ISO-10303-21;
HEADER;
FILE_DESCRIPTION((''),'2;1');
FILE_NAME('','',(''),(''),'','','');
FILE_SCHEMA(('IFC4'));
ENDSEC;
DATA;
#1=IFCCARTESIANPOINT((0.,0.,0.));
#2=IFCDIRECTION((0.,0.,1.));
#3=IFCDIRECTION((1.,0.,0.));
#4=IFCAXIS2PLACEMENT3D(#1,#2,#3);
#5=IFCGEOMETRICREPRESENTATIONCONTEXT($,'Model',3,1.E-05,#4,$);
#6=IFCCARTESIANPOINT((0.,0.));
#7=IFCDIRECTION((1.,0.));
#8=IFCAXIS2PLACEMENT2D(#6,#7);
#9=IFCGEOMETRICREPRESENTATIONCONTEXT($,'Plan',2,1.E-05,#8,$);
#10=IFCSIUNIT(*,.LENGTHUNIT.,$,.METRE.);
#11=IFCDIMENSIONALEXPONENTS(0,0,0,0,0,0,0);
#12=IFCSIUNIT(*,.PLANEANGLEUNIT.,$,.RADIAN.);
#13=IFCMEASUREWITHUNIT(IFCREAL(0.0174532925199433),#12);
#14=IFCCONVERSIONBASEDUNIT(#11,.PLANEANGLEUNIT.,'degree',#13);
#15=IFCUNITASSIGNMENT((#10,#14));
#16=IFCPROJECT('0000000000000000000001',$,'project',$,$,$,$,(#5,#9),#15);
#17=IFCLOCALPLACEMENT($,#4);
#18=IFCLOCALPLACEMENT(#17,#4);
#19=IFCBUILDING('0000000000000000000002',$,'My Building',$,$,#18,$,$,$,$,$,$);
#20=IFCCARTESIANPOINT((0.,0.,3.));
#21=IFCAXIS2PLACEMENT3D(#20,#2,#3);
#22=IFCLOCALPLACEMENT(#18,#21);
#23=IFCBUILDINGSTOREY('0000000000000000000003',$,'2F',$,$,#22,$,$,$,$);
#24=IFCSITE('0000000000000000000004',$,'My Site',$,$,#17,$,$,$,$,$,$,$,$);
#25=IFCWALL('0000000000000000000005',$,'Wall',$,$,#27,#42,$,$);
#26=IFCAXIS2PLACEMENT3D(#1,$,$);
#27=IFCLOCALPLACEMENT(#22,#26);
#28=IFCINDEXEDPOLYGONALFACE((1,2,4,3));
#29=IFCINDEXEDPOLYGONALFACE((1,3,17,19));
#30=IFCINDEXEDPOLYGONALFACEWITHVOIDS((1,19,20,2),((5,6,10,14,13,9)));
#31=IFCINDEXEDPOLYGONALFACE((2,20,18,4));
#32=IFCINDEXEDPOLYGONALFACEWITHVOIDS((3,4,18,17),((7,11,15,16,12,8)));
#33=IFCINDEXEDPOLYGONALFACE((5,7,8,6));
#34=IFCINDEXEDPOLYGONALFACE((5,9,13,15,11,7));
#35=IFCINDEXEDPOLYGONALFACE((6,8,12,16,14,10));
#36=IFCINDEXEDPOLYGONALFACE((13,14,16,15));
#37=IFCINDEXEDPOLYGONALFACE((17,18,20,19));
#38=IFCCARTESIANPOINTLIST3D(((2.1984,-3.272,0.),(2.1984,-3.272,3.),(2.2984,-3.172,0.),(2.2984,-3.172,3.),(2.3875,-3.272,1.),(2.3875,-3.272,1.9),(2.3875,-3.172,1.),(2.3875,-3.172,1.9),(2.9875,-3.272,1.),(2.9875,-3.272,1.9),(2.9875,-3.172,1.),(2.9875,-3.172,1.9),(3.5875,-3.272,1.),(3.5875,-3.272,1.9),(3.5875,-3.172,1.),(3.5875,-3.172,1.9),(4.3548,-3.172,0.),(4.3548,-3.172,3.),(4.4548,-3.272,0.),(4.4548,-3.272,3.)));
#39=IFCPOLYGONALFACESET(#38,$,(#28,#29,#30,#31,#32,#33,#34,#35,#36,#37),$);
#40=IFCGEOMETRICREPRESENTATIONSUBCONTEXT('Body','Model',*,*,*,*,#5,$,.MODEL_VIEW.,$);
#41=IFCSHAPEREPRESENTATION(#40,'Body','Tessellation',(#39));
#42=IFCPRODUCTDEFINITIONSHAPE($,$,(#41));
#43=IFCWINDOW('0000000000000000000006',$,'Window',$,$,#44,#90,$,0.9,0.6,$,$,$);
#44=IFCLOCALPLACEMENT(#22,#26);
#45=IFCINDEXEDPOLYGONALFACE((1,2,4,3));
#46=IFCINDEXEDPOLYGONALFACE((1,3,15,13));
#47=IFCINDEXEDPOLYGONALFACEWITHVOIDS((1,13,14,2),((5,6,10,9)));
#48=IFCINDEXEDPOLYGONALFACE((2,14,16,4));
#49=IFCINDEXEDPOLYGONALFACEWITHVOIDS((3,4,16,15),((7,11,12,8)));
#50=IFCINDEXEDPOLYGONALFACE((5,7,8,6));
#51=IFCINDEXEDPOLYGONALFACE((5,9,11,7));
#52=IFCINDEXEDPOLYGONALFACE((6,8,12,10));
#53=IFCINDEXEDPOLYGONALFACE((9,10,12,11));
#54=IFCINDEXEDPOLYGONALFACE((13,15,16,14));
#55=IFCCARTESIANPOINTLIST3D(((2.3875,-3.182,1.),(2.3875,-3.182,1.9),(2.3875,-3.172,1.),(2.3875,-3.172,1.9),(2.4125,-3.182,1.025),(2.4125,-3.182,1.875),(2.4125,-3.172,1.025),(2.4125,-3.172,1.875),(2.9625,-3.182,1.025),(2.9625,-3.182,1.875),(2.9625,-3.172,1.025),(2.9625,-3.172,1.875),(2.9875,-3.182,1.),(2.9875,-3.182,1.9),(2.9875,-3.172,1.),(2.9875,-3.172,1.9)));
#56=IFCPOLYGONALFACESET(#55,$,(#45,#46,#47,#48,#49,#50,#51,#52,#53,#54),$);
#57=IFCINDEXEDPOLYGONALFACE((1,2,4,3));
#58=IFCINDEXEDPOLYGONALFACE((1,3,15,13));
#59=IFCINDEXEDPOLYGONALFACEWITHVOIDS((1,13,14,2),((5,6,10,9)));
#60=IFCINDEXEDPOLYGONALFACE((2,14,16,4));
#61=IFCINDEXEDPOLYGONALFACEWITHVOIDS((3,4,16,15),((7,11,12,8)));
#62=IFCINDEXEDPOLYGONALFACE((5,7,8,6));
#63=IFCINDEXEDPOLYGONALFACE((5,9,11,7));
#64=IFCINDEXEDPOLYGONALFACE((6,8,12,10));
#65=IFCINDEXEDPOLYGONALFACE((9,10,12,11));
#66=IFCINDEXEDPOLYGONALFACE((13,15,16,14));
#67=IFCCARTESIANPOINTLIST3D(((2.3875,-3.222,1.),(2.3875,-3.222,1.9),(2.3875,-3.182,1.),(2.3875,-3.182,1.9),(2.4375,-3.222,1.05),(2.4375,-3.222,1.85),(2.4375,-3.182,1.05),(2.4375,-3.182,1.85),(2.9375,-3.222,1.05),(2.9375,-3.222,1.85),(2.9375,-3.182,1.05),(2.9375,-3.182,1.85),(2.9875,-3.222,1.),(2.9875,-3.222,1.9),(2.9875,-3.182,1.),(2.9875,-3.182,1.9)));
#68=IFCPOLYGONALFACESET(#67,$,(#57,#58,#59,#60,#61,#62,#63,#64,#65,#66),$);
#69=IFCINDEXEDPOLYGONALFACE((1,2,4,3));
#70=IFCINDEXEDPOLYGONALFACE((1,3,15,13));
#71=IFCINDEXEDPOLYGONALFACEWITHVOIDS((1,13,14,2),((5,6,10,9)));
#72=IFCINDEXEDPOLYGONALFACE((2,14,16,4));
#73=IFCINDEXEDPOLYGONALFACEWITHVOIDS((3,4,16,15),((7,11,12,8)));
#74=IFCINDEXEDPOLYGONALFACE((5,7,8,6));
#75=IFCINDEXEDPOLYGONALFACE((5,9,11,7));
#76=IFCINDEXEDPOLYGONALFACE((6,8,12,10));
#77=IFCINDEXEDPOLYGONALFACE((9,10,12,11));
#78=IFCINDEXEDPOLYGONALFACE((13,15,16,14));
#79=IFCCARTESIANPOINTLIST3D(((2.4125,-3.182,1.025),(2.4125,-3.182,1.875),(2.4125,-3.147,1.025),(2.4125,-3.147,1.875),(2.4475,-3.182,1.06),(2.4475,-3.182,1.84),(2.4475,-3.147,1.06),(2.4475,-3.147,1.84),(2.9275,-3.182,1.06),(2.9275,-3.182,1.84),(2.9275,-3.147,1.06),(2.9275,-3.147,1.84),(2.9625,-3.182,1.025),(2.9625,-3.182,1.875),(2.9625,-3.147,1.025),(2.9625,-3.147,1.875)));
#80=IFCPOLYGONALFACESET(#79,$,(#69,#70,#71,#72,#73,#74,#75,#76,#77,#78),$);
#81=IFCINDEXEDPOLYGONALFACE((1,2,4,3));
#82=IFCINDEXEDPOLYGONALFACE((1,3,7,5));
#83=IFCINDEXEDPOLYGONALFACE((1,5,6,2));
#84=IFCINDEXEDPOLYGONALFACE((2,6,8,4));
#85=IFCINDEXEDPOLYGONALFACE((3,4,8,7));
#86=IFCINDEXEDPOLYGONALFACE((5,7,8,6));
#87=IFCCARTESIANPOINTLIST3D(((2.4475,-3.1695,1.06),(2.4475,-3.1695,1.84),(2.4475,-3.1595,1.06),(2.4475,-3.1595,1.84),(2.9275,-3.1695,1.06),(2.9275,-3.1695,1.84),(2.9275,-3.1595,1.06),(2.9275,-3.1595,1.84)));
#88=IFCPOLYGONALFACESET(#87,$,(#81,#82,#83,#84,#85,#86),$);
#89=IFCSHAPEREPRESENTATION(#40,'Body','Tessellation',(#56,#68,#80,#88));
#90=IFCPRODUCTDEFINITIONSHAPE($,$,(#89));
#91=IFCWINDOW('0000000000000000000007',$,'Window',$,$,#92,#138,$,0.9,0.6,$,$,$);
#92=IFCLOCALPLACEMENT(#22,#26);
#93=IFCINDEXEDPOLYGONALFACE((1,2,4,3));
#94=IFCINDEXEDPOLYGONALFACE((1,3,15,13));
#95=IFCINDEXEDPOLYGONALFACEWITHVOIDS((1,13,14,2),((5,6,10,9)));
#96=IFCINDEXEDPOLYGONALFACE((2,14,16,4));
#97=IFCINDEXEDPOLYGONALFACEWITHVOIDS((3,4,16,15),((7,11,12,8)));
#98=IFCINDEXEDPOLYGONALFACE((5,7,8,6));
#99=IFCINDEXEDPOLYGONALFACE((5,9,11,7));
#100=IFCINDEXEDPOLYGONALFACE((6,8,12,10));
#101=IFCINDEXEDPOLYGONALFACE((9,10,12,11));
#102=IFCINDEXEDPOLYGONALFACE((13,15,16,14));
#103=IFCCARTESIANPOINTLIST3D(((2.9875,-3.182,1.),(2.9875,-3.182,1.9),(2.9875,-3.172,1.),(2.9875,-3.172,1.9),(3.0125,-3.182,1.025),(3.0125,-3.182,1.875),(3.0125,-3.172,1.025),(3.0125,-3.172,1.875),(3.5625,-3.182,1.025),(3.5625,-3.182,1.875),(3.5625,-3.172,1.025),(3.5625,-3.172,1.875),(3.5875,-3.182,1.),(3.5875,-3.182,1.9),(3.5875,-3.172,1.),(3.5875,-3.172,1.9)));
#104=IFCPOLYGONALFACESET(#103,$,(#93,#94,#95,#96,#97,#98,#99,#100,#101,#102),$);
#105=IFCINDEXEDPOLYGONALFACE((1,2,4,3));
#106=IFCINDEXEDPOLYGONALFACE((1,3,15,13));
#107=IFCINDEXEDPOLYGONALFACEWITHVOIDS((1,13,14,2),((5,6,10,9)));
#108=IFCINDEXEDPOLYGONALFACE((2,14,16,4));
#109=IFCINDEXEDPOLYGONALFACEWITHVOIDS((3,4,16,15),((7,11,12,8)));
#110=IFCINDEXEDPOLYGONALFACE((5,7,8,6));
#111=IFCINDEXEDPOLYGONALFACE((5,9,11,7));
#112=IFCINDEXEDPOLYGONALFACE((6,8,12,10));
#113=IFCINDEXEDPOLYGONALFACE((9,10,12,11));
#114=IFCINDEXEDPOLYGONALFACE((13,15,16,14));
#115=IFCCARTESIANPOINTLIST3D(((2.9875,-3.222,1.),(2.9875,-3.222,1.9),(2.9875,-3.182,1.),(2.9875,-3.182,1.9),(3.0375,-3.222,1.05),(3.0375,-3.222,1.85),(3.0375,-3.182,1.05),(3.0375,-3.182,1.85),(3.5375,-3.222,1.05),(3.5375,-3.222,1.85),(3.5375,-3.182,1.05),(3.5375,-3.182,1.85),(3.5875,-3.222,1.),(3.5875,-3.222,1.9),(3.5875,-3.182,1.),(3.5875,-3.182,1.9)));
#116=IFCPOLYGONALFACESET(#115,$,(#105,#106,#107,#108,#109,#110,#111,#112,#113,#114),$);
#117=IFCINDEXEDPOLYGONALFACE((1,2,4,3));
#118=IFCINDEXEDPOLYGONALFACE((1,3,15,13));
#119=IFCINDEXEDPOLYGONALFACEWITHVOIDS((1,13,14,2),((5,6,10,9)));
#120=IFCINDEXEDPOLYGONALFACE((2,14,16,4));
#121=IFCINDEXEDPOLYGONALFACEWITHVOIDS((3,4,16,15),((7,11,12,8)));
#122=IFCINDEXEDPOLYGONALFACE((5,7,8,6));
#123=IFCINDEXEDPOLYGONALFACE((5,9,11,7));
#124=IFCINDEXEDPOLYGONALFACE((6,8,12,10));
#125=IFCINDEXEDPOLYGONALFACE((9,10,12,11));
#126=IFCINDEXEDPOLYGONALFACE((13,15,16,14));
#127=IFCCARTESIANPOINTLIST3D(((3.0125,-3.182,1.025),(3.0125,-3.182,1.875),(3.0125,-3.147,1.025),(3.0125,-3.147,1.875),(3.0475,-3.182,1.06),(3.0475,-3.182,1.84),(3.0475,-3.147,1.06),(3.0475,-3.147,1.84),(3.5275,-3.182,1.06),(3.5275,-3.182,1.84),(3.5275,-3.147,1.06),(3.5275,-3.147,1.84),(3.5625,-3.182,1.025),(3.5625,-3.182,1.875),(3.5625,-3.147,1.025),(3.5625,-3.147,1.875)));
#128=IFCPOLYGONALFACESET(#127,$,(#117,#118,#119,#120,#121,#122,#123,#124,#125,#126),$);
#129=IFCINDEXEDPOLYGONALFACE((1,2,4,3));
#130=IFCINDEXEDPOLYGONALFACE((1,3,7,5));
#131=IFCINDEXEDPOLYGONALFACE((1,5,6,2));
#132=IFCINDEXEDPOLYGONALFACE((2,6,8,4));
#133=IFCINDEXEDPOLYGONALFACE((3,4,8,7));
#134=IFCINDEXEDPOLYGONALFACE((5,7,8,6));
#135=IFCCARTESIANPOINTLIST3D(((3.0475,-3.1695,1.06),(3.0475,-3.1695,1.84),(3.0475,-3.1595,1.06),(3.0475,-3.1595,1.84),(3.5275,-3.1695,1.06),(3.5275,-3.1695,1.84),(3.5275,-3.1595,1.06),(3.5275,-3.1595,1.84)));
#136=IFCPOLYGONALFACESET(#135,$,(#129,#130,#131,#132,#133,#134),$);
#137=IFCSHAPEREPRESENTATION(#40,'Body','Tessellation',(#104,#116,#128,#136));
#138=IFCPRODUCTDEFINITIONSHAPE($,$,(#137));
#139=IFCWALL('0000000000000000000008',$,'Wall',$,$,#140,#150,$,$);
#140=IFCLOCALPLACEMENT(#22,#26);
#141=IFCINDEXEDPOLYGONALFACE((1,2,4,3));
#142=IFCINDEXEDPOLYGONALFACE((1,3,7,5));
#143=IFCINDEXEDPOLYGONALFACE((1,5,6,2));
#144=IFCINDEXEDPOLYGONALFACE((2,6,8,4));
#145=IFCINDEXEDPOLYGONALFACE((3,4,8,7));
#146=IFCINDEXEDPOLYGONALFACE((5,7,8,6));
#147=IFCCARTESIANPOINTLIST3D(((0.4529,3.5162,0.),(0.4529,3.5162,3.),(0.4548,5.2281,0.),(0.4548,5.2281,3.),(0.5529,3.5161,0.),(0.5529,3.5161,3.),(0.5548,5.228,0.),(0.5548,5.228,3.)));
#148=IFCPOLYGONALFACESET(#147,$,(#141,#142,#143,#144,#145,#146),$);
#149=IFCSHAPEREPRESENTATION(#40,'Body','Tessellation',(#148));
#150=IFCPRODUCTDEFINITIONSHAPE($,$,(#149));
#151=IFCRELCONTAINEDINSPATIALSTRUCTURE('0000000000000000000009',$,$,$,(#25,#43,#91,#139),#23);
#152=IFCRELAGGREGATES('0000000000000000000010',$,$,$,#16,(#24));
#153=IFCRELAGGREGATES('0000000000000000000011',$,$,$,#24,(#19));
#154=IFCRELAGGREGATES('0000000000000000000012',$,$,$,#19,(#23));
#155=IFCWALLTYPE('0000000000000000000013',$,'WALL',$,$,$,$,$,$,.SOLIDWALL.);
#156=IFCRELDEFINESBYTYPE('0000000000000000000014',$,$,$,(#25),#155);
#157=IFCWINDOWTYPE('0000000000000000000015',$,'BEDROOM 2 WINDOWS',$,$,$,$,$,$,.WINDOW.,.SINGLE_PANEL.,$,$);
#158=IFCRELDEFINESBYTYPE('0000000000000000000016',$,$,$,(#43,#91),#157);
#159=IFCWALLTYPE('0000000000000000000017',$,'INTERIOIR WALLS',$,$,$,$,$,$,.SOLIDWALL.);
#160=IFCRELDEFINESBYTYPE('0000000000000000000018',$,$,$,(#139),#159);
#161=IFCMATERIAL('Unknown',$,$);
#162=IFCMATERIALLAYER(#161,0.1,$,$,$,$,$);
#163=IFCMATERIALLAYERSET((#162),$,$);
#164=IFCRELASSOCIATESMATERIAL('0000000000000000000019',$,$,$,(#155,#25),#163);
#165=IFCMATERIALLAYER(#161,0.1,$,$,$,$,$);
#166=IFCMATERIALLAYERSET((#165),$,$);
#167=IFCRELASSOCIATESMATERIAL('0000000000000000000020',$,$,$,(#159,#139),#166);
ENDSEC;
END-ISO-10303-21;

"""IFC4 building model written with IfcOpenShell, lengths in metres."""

from ifc_helpers import new_model, entity, si_unit, converted_unit, frame, origin_with_axes, origin_2d_with_axis, place, context, subcontext, project, spatial, line, indexed_curve, outline, extrude, shape, source, transform, mapped, material, layer, layer_set, layer_usage, type_object, type_shapes, element, fill, save


model = new_model("IFC4")

# Units and contexts
model_context = context("Model", 3, precision=1e-05, world=origin_with_axes())
plan_context = context("Plan", 2, precision=1e-05, world=origin_2d_with_axis())
body_context_1 = subcontext(model_context, "Body", "Model", "MODEL_VIEW")
body_context_2 = subcontext(plan_context, "Body", "Plan", "PLAN_VIEW")
ifc_project = project(units=[si_unit("LENGTHUNIT", "METRE"), converted_unit("PLANEANGLEUNIT", "degree", entity("IfcReal", 0.0174532925199433), si_unit("PLANEANGLEUNIT", "RADIAN"), dimensions=[0, 0, 0, 0, 0, 0, 0])], contexts=[model_context, plan_context])

# Site, building, storey
site_placement = place(None, origin_with_axes())
site = spatial("IfcSite", under=ifc_project, at=site_placement, Name="My Site")
building_placement = place(site_placement, origin_with_axes())
building = spatial("IfcBuilding", under=site, at=building_placement, Name="My Building")
storey_placement = place(building_placement, frame((0.0, 0.0, 3.0), z_axis=(0.0, 0.0, 1.0), x_axis=(1.0, 0.0, 0.0)))
storey = spatial("IfcBuildingStorey", under=building, at=storey_placement, Name="2F")

# Shared definitions
ifc_material = material(Name="Unknown")

# Shared definitions
ifc_layer_1 = layer(ifc_material, 0.1)
ifc_layer_set_1 = layer_set([ifc_layer_1])
wall_type_1 = type_object("IfcWallType", Name="WALL", PredefinedType="SOLIDWALL", material=ifc_layer_set_1)

# Wall, openings, windows
ifc_layer_usage_1 = layer_usage(ifc_layer_set_1, "AXIS2", "POSITIVE", 0.0)
wall_1_placement = place(storey_placement, frame((2.1984, -3.272, 0.0), z_axis=(0.0, 0.0, 1.0), x_axis=(1.0, 0.0, 0.0)))
wall_1 = element("IfcWall", 1, at=wall_1_placement, inside=storey, type_object=wall_type_1, material=ifc_layer_usage_1, Name="Wall", context=body_context_1, shape_type="SweptSolid", body=[
    extrude(outline(indexed_curve([(0.0, 0.0), (0.1, 0.1), (2.1564, 0.1), (2.2564, 0.0)], segments=[line(1, 2, 3, 4, 1)])), origin_with_axes(), (0.0, 0.0, 1.0), 3.0),
])
shared_shape_1 = source(origin_with_axes(), body_context_1, "Body", "SweptSolid", [
    extrude(outline(indexed_curve([(0.0, 0.0), (0.6, 0.0), (0.6, 0.9), (0.0, 0.9)], segments=[line(1, 2, 3, 4, 1)])), frame((0.0, -0.6, 0.0), z_axis=(0.0, -1.0, 0.0), x_axis=(1.0, 0.0, 0.0)), (0.0, 0.0, -1.0), 1.2),
])
opening_1_placement = place(wall_1_placement, frame((0.1891, 0.0, 1.0), z_axis=(0.0, 0.0, 1.0), x_axis=(1.0, 0.0, 0.0)))
opening_1 = element("IfcOpeningElement", 2, at=opening_1_placement, cuts=wall_1, PredefinedType="OPENING", context=body_context_1, shape_type="MappedRepresentation", body=[
    mapped(shared_shape_1, transform((0.0, 0.0, 0.0), x_axis=(1.0, 0.0, 0.0), y_axis=(0.0, 1.0, 0.0), z_axis=(0.0, 0.0, 1.0), scale=1.0)),
])
opening_2_placement = place(wall_1_placement, frame((0.7891, 0.0, 1.0), z_axis=(0.0, 0.0, 1.0), x_axis=(1.0, 0.0, 0.0)))
opening_2 = element("IfcOpeningElement", 3, at=opening_2_placement, cuts=wall_1, PredefinedType="OPENING", context=body_context_1, shape_type="MappedRepresentation", body=[
    mapped(shared_shape_1, transform((0.0, 0.0, 0.0), x_axis=(1.0, 0.0, 0.0), y_axis=(0.0, 1.0, 0.0), z_axis=(0.0, 0.0, 1.0), scale=1.0)),
])
window_type_1 = type_object("IfcWindowType", Name="BEDROOM 2 WINDOWS", PartitioningType="SINGLE_PANEL", PredefinedType="WINDOW")
shared_shape_2 = source(origin_with_axes(), body_context_1, "Body", "SweptSolid", [
    extrude(outline(indexed_curve([(0.0, 0.0), (0.6, 0.0), (0.6, 0.9), (0.0, 0.9)], segments=[line(1, 2, 3, 4, 1)]), holes=[indexed_curve([(0.025, 0.025), (0.575, 0.025), (0.575, 0.875), (0.025, 0.875)], segments=[line(1, 2, 3, 4, 1)])]), frame((0.0, 0.09, 0.0), z_axis=(0.0, -1.0, 0.0), x_axis=(1.0, 0.0, 0.0)), (0.0, 0.0, -1.0), 0.01),
    extrude(outline(indexed_curve([(0.0, 0.0), (0.6, 0.0), (0.6, 0.9), (0.0, 0.9)], segments=[line(1, 2, 3, 4, 1)]), holes=[indexed_curve([(0.05, 0.05), (0.55, 0.05), (0.55, 0.85), (0.05, 0.85)], segments=[line(1, 2, 3, 4, 1)])]), frame((0.0, 0.05, 0.0), z_axis=(0.0, -1.0, 0.0), x_axis=(1.0, 0.0, 0.0)), (0.0, 0.0, -1.0), 0.04),
    extrude(outline(indexed_curve([(0.0, 0.0), (0.55, 0.0), (0.55, 0.85), (0.0, 0.85)], segments=[line(1, 2, 3, 4, 1)]), holes=[indexed_curve([(0.035, 0.035), (0.515, 0.035), (0.515, 0.815), (0.035, 0.815)], segments=[line(1, 2, 3, 4, 1)])]), frame((0.025, 0.09, 0.025), z_axis=(0.0, -1.0, 0.0), x_axis=(1.0, 0.0, 0.0)), (0.0, 0.0, -1.0), 0.035),
    extrude(outline(indexed_curve([(0.035, 0.035), (0.515, 0.035), (0.515, 0.815), (0.035, 0.815)], segments=[line(1, 2, 3, 4, 1)])), frame((0.025, 0.1025, 0.025), z_axis=(0.0, -1.0, 0.0), x_axis=(1.0, 0.0, 0.0)), (0.0, 0.0, -1.0), 0.01),
])
shared_shape_3 = source(origin_with_axes(), body_context_2, "Body", "Curve2D", [
    entity("IfcIndexedPolyCurve", entity("IfcCartesianPointList2D", [[0.05, 0.05], [0.55, 0.05]])),
    entity("IfcIndexedPolyCurve", entity("IfcCartesianPointList2D", [[0.0, 0.1], [0.025, 0.1], [0.025, 0.09], [0.05, 0.09], [0.05, 0.05], [0.0, 0.05]]), [entity("IfcLineIndex", [1, 2, 3, 4, 5, 6, 1])]),
    entity("IfcIndexedPolyCurve", entity("IfcCartesianPointList2D", [[0.6, 0.1], [0.575, 0.1], [0.575, 0.09], [0.55, 0.09], [0.55, 0.05], [0.6, 0.05]]), [entity("IfcLineIndex", [1, 2, 3, 4, 5, 6, 1])]),
    entity("IfcIndexedPolyCurve", entity("IfcCartesianPointList2D", [[0.025, 0.09], [0.06, 0.09], [0.06, 0.125], [0.025, 0.125]]), [entity("IfcLineIndex", [1, 2, 3, 4, 1])]),
    entity("IfcIndexedPolyCurve", entity("IfcCartesianPointList2D", [[0.575, 0.09], [0.54, 0.09], [0.54, 0.125], [0.575, 0.125]]), [entity("IfcLineIndex", [1, 2, 3, 4, 1])]),
    entity("IfcIndexedPolyCurve", entity("IfcCartesianPointList2D", [[0.06, 0.09], [0.54, 0.09]])),
    entity("IfcIndexedPolyCurve", entity("IfcCartesianPointList2D", [[0.06, 0.125], [0.54, 0.125]])),
    entity("IfcIndexedPolyCurve", entity("IfcCartesianPointList2D", [[0.06, 0.1075], [0.54, 0.1075]])),
])
type_shapes(window_type_1, [shared_shape_2, shared_shape_3])
window_1_placement = place(opening_1_placement, origin_with_axes())
window_1 = element("IfcWindow", 4, at=window_1_placement, inside=storey, type_object=window_type_1, Name="Window", OverallHeight=0.9, OverallWidth=0.6, shapes=[
    shape(body_context_1, "Body", "MappedRepresentation", [mapped(shared_shape_2, transform((0.0, 0.0, 0.0), x_axis=(1.0, 0.0, 0.0), y_axis=(0.0, 1.0, 0.0), z_axis=(0.0, 0.0, 1.0), scale=1.0))]),
    shape(body_context_2, "Body", "MappedRepresentation", [mapped(shared_shape_3, transform((0.0, 0.0, 0.0), x_axis=(1.0, 0.0, 0.0), y_axis=(0.0, 1.0, 0.0), z_axis=(0.0, 0.0, 1.0), scale=1.0))]),
])
fill(opening_1, window_1)
window_2_placement = place(opening_2_placement, origin_with_axes())
window_2 = element("IfcWindow", 5, at=window_2_placement, inside=storey, type_object=window_type_1, Name="Window", OverallHeight=0.9, OverallWidth=0.6, shapes=[
    shape(body_context_1, "Body", "MappedRepresentation", [mapped(shared_shape_2, transform((0.0, 0.0, 0.0), x_axis=(1.0, 0.0, 0.0), y_axis=(0.0, 1.0, 0.0), z_axis=(0.0, 0.0, 1.0), scale=1.0))]),
    shape(body_context_2, "Body", "MappedRepresentation", [mapped(shared_shape_3, transform((0.0, 0.0, 0.0), x_axis=(1.0, 0.0, 0.0), y_axis=(0.0, 1.0, 0.0), z_axis=(0.0, 0.0, 1.0), scale=1.0))]),
])
fill(opening_2, window_2)

# Wall
ifc_layer_2 = layer(ifc_material, 0.1)
ifc_layer_set_2 = layer_set([ifc_layer_2])
ifc_layer_usage_2 = layer_usage(ifc_layer_set_2, "AXIS2", "POSITIVE", 0.0)
wall_type_2 = type_object("IfcWallType", Name="INTERIOIR WALLS", PredefinedType="SOLIDWALL", material=ifc_layer_set_2)
wall_2_placement = place(storey_placement, frame((0.4548, 5.2281, 0.0), z_axis=(0.0, 0.0, 1.0), x_axis=(-0.001084, -0.999999, 0.0)))
element("IfcWall", 6, at=wall_2_placement, inside=storey, type_object=wall_type_2, material=ifc_layer_usage_2, Name="Wall", context=body_context_1, shape_type="SweptSolid", body=[
    extrude(outline(indexed_curve([(0.0, 0.0), (0.0, 0.1), (1.7119, 0.1), (1.7119, 0.0)], segments=[line(1, 2, 3, 4, 1)])), origin_with_axes(), (0.0, 0.0, 1.0), 3.0),
])

save(model, "model.ifc")
